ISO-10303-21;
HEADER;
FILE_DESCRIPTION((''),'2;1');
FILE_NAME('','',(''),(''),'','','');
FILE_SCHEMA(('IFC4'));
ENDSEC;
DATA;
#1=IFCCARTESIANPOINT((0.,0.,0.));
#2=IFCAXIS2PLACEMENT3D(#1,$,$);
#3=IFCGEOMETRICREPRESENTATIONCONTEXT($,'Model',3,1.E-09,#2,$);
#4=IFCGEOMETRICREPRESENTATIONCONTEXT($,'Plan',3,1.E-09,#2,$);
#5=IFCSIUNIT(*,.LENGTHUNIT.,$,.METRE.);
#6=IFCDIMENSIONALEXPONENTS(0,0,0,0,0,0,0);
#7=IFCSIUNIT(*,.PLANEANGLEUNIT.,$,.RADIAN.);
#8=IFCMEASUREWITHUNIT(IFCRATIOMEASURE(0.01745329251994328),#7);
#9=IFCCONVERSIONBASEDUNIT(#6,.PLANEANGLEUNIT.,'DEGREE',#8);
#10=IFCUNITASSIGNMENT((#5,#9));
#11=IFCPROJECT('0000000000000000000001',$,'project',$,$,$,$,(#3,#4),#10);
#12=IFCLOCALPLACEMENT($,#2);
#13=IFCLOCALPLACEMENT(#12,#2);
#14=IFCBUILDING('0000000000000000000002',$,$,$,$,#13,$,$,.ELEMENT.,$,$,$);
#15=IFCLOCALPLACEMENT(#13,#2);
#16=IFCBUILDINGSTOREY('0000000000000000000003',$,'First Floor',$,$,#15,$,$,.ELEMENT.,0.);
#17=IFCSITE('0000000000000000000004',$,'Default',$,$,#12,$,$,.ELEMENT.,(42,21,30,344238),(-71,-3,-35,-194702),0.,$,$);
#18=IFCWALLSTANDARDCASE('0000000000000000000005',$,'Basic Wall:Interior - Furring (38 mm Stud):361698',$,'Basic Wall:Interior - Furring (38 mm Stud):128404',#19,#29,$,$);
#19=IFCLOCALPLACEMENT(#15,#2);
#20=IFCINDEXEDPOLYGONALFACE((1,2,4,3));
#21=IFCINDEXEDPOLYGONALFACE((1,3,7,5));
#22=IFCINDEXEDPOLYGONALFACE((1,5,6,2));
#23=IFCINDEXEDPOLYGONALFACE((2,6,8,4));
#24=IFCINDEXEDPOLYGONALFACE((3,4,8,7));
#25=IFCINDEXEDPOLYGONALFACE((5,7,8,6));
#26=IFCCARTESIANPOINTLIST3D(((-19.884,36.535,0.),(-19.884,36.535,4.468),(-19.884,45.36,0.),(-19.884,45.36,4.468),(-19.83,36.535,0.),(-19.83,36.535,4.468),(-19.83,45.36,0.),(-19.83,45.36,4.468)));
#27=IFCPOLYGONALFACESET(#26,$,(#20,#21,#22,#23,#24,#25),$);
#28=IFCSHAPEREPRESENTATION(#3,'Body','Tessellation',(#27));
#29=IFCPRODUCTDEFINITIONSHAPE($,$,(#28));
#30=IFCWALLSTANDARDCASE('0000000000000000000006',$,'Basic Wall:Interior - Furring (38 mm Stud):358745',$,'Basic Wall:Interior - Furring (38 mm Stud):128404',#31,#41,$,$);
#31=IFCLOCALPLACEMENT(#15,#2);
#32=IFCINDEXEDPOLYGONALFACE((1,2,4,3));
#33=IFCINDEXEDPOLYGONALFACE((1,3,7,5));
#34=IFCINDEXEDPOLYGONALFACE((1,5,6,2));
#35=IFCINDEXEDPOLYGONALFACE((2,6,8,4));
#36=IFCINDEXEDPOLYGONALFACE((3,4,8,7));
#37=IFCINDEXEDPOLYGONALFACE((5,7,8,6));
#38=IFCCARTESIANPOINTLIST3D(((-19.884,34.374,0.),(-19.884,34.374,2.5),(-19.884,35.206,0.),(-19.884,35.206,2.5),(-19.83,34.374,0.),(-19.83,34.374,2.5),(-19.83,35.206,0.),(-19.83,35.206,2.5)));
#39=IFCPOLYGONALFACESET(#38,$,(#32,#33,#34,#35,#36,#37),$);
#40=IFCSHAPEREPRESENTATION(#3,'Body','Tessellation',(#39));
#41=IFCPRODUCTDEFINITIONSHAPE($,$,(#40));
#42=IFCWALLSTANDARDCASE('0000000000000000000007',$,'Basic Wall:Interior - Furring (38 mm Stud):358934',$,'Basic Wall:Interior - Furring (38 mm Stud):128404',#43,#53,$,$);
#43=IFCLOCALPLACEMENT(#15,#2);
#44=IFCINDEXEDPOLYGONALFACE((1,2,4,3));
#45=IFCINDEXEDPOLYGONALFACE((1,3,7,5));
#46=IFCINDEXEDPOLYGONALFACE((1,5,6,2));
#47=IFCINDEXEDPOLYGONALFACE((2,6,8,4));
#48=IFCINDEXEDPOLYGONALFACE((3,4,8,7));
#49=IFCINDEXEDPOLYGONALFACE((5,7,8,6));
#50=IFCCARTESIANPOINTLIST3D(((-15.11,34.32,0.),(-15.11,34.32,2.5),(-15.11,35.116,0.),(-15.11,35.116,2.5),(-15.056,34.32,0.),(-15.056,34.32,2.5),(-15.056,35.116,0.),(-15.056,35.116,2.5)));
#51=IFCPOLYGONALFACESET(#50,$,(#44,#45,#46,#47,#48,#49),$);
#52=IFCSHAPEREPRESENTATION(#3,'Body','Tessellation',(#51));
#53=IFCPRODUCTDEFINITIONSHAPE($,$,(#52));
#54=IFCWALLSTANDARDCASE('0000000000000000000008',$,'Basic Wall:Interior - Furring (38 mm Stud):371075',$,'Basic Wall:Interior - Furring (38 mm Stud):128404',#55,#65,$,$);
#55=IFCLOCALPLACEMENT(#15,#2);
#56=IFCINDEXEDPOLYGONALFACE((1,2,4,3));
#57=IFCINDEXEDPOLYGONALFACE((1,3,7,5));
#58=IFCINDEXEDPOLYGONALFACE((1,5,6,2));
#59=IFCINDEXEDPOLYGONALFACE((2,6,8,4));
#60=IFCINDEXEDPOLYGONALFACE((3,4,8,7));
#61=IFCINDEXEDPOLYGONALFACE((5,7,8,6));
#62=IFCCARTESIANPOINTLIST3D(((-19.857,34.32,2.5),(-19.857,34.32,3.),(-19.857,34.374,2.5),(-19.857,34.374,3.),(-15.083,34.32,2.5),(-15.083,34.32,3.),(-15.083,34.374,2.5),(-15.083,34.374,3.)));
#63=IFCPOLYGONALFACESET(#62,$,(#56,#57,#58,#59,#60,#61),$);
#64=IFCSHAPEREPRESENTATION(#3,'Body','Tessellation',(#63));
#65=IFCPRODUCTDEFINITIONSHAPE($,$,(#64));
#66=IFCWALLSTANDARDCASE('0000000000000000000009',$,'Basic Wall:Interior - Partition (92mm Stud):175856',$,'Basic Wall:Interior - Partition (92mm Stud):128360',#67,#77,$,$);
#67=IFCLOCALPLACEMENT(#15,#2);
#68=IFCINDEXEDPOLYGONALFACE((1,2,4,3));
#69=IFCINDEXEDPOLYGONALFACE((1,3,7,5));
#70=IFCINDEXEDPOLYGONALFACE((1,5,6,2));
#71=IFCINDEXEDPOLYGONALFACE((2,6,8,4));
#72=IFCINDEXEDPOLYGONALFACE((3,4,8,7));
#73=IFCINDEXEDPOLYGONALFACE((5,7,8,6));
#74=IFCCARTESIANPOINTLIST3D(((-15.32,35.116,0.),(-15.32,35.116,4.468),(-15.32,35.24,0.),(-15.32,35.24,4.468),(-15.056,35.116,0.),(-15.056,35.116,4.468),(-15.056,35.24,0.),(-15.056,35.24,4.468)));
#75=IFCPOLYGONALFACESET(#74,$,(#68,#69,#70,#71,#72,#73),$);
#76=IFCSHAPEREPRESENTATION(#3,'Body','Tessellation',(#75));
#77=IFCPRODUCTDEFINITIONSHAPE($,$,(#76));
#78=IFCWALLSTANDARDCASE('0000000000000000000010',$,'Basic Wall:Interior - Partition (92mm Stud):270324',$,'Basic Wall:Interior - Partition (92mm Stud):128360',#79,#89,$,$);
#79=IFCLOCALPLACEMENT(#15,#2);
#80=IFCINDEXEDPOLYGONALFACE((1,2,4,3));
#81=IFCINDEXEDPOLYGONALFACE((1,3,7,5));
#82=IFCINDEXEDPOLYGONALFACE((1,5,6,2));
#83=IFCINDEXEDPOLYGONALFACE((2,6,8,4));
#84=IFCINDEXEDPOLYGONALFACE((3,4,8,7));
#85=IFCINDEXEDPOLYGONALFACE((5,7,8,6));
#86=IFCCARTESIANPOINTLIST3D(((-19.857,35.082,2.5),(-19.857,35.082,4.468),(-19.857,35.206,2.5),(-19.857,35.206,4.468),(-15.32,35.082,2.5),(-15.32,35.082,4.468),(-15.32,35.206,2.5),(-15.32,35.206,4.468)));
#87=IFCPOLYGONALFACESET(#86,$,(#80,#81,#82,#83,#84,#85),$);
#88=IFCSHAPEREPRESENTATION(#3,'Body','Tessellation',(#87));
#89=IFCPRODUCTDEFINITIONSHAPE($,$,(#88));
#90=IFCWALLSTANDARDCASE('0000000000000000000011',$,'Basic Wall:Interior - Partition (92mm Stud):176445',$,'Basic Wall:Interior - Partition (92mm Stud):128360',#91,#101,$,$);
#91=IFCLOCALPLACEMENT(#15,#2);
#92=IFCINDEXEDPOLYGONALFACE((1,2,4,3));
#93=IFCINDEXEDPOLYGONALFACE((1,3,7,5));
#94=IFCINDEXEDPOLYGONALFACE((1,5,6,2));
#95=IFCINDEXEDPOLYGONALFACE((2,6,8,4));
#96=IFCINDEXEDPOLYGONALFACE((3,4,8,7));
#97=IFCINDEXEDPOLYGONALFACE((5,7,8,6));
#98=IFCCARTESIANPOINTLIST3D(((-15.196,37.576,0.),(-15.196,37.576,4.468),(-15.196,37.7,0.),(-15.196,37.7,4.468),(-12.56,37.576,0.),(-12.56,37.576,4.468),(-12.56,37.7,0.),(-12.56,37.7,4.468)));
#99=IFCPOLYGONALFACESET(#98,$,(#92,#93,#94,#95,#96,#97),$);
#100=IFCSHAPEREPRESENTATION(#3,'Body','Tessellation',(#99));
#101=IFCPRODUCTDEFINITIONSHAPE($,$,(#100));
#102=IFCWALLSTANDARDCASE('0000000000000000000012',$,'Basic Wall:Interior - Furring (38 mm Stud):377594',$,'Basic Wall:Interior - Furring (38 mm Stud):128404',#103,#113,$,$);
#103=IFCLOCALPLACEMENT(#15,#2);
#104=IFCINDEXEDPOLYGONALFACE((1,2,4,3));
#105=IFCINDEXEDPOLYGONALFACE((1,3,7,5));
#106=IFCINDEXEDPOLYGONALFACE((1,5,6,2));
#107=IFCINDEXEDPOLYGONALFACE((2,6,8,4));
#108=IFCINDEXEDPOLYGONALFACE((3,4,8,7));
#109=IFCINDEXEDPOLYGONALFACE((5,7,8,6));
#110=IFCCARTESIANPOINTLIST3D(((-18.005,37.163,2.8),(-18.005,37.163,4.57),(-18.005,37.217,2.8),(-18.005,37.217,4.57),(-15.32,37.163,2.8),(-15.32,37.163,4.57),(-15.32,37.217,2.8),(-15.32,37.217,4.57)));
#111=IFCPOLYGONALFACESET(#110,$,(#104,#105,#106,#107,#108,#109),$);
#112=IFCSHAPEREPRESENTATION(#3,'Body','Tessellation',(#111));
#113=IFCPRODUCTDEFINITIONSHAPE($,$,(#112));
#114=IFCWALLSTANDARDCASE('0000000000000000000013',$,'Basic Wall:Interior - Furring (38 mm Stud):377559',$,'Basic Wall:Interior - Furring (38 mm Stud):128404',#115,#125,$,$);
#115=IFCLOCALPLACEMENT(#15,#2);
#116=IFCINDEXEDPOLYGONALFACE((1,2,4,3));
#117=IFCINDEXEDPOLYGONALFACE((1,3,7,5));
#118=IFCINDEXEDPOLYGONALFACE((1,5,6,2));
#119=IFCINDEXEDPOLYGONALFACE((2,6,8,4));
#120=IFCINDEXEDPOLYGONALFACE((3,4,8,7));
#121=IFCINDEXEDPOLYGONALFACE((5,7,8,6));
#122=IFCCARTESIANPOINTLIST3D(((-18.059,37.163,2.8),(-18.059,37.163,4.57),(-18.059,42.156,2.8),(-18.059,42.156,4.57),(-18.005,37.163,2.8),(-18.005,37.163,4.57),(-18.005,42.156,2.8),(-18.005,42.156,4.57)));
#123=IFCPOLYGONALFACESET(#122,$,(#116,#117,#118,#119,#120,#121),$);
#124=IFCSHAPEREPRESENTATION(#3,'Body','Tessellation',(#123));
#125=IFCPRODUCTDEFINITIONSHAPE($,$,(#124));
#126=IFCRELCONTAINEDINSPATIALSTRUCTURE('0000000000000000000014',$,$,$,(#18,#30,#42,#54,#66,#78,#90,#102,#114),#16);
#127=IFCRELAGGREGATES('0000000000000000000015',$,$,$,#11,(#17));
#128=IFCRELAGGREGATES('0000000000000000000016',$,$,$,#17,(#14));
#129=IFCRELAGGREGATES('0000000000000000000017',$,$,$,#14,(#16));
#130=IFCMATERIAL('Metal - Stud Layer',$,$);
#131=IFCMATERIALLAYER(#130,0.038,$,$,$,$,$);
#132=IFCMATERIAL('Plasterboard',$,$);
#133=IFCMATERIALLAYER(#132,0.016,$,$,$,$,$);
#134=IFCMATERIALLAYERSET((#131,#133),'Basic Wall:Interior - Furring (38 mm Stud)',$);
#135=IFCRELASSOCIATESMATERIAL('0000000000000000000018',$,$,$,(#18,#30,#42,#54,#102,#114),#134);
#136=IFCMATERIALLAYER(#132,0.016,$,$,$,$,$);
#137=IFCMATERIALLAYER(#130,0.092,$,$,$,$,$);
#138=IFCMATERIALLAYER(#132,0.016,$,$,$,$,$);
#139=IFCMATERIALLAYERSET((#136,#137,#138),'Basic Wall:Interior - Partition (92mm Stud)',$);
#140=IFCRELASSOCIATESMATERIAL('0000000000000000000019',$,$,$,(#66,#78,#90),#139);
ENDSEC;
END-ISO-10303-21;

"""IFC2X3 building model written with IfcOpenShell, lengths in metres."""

from ifc_helpers import new_model, entity, si_unit, converted_unit, frame, frame_2d, origin, place, context, project, spatial, rectangle, extrude, material, layer, layer_set, layer_usage, element, save


model = new_model("IFC2X3")

# Units and contexts
model_context = context("Model", 3, precision=1e-09, world=origin())
plan_context = context("Plan", 3, precision=1e-09, world=origin())
ifc_project = project(units=[si_unit("LENGTHUNIT", "METRE"), converted_unit("PLANEANGLEUNIT", "DEGREE", entity("IfcRatioMeasure", 0.01745329251994328), si_unit("PLANEANGLEUNIT", "RADIAN"), dimensions=[0, 0, 0, 0, 0, 0, 0])], contexts=[model_context, plan_context])

# Site, building, storey
site_placement = place(None, origin())
site = spatial("IfcSite", under=ifc_project, at=site_placement, Name="Default", CompositionType="ELEMENT", RefLatitude=(42, 21, 30, 344238), RefLongitude=(-71, -3, -35, -194702), RefElevation=0.0)
building_placement = place(site_placement, origin())
building = spatial("IfcBuilding", under=site, at=building_placement, CompositionType="ELEMENT")
storey_placement = place(building_placement, origin())
storey = spatial("IfcBuildingStorey", under=building, at=storey_placement, Name="First Floor", CompositionType="ELEMENT", Elevation=0.0)

# Shared definitions
ifc_material_1 = material(Name="Plasterboard")
ifc_layer_1 = layer(ifc_material_1, 0.016)
ifc_material_2 = material(Name="Metal - Stud Layer")
ifc_layer_2 = layer(ifc_material_2, 0.092)
ifc_layer_3 = layer(ifc_material_1, 0.016)
ifc_layer_set_1 = layer_set([ifc_layer_1, ifc_layer_2, ifc_layer_3], Name="Basic Wall:Interior - Partition (92mm Stud)")
ifc_layer_usage_1 = layer_usage(ifc_layer_set_1, "AXIS2", "NEGATIVE", 0.062)

# Walls
ifc_layer_4 = layer(ifc_material_2, 0.038)
ifc_layer_5 = layer(ifc_material_1, 0.016)
ifc_layer_set_2 = layer_set([ifc_layer_4, ifc_layer_5], Name="Basic Wall:Interior - Furring (38 mm Stud)")
ifc_layer_usage_2 = layer_usage(ifc_layer_set_2, "AXIS2", "NEGATIVE", 0.027)
wall_1_placement = place(storey_placement, frame((-19.857, 36.535, 0.0), z_axis=(0.0, 0.0, 1.0), x_axis=(0.0, 1.0, 0.0)))
element("IfcWallStandardCase", 1, at=wall_1_placement, inside=storey, material=ifc_layer_usage_2, Name="Basic Wall:Interior - Furring (38 mm Stud):361698", ObjectType="Basic Wall:Interior - Furring (38 mm Stud):128404", context=model_context, shape_type="SweptSolid", body=[
    extrude(rectangle(XDim=8.825, YDim=0.054, at=frame_2d((4.4125, 0.0), x_axis=(-1.0, 0.0))), origin(), (0.0, 0.0, 1.0), 4.468),
])
wall_2_placement = place(storey_placement, frame((-19.857, 34.374, 0.0), z_axis=(0.0, 0.0, 1.0), x_axis=(0.0, 1.0, 0.0)))
element("IfcWallStandardCase", 2, at=wall_2_placement, inside=storey, material=ifc_layer_usage_2, Name="Basic Wall:Interior - Furring (38 mm Stud):358745", ObjectType="Basic Wall:Interior - Furring (38 mm Stud):128404", context=model_context, shape_type="SweptSolid", body=[
    extrude(rectangle(XDim=0.832, YDim=0.054, at=frame_2d((0.416, 0.0), x_axis=(-1.0, 0.0))), origin(), (0.0, 0.0, 1.0), 2.5),
])
wall_3_placement = place(storey_placement, frame((-15.083, 35.116, 0.0), z_axis=(0.0, 0.0, 1.0), x_axis=(0.0, -1.0, 0.0)))
element("IfcWallStandardCase", 3, at=wall_3_placement, inside=storey, material=ifc_layer_usage_2, Name="Basic Wall:Interior - Furring (38 mm Stud):358934", ObjectType="Basic Wall:Interior - Furring (38 mm Stud):128404", context=model_context, shape_type="SweptSolid", body=[
    extrude(rectangle(XDim=0.796, YDim=0.054, at=frame_2d((0.398, 0.0), x_axis=(-1.0, 0.0))), origin(), (0.0, 0.0, 1.0), 2.5),
])
wall_4_placement = place(storey_placement, frame((-19.857, 34.347, 2.5)))
element("IfcWallStandardCase", 4, at=wall_4_placement, inside=storey, material=ifc_layer_usage_2, Name="Basic Wall:Interior - Furring (38 mm Stud):371075", ObjectType="Basic Wall:Interior - Furring (38 mm Stud):128404", context=model_context, shape_type="SweptSolid", body=[
    extrude(rectangle(XDim=4.774, YDim=0.054, at=frame_2d((2.387, 0.0), x_axis=(-1.0, 0.0))), origin(), (0.0, 0.0, 1.0), 0.5),
])
wall_5_placement = place(storey_placement, frame((-15.056, 35.178, 0.0), z_axis=(0.0, 0.0, 1.0), x_axis=(-1.0, 0.0, 0.0)))
element("IfcWallStandardCase", 5, at=wall_5_placement, inside=storey, material=ifc_layer_usage_1, Name="Basic Wall:Interior - Partition (92mm Stud):175856", ObjectType="Basic Wall:Interior - Partition (92mm Stud):128360", context=model_context, shape_type="SweptSolid", body=[
    extrude(rectangle(XDim=0.264, YDim=0.124, at=frame_2d((0.132, 0.0), x_axis=(-1.0, 0.0))), origin(), (0.0, 0.0, 1.0), 4.468),
])
wall_6_placement = place(storey_placement, frame((-19.857, 35.144, 2.5)))
element("IfcWallStandardCase", 6, at=wall_6_placement, inside=storey, material=ifc_layer_usage_1, Name="Basic Wall:Interior - Partition (92mm Stud):270324", ObjectType="Basic Wall:Interior - Partition (92mm Stud):128360", context=model_context, shape_type="SweptSolid", body=[
    extrude(rectangle(XDim=4.537, YDim=0.124, at=frame_2d((2.2685, 0.0), x_axis=(-1.0, 0.0))), origin(), (0.0, 0.0, 1.0), 1.968),
])
wall_7_placement = place(storey_placement, frame((-15.196, 37.638, 0.0)))
element("IfcWallStandardCase", 7, at=wall_7_placement, inside=storey, material=ifc_layer_usage_1, Name="Basic Wall:Interior - Partition (92mm Stud):176445", ObjectType="Basic Wall:Interior - Partition (92mm Stud):128360", context=model_context, shape_type="SweptSolid", body=[
    extrude(rectangle(XDim=2.636, YDim=0.124, at=frame_2d((1.318, 0.0), x_axis=(-1.0, 0.0))), origin(), (0.0, 0.0, 1.0), 4.468),
])
ifc_layer_usage_3 = layer_usage(ifc_layer_set_2, "AXIS2", "POSITIVE", -0.027)
wall_8_placement = place(storey_placement, frame((-18.005, 37.19, 2.8)))
element("IfcWallStandardCase", 8, at=wall_8_placement, inside=storey, material=ifc_layer_usage_3, Name="Basic Wall:Interior - Furring (38 mm Stud):377594", ObjectType="Basic Wall:Interior - Furring (38 mm Stud):128404", context=model_context, shape_type="SweptSolid", body=[
    extrude(rectangle(XDim=2.685, YDim=0.054, at=frame_2d((1.3425, 0.0), x_axis=(-1.0, 0.0))), origin(), (0.0, 0.0, 1.0), 1.77),
])
wall_9_placement = place(storey_placement, frame((-18.032, 42.156, 2.8), z_axis=(0.0, 0.0, 1.0), x_axis=(0.0, -1.0, 0.0)))
element("IfcWallStandardCase", 9, at=wall_9_placement, inside=storey, material=ifc_layer_usage_3, Name="Basic Wall:Interior - Furring (38 mm Stud):377559", ObjectType="Basic Wall:Interior - Furring (38 mm Stud):128404", context=model_context, shape_type="SweptSolid", body=[
    extrude(rectangle(XDim=4.993, YDim=0.054, at=frame_2d((2.4965, 0.0), x_axis=(-1.0, 0.0))), origin(), (0.0, 0.0, 1.0), 1.77),
])

save(model, "model.ifc")
